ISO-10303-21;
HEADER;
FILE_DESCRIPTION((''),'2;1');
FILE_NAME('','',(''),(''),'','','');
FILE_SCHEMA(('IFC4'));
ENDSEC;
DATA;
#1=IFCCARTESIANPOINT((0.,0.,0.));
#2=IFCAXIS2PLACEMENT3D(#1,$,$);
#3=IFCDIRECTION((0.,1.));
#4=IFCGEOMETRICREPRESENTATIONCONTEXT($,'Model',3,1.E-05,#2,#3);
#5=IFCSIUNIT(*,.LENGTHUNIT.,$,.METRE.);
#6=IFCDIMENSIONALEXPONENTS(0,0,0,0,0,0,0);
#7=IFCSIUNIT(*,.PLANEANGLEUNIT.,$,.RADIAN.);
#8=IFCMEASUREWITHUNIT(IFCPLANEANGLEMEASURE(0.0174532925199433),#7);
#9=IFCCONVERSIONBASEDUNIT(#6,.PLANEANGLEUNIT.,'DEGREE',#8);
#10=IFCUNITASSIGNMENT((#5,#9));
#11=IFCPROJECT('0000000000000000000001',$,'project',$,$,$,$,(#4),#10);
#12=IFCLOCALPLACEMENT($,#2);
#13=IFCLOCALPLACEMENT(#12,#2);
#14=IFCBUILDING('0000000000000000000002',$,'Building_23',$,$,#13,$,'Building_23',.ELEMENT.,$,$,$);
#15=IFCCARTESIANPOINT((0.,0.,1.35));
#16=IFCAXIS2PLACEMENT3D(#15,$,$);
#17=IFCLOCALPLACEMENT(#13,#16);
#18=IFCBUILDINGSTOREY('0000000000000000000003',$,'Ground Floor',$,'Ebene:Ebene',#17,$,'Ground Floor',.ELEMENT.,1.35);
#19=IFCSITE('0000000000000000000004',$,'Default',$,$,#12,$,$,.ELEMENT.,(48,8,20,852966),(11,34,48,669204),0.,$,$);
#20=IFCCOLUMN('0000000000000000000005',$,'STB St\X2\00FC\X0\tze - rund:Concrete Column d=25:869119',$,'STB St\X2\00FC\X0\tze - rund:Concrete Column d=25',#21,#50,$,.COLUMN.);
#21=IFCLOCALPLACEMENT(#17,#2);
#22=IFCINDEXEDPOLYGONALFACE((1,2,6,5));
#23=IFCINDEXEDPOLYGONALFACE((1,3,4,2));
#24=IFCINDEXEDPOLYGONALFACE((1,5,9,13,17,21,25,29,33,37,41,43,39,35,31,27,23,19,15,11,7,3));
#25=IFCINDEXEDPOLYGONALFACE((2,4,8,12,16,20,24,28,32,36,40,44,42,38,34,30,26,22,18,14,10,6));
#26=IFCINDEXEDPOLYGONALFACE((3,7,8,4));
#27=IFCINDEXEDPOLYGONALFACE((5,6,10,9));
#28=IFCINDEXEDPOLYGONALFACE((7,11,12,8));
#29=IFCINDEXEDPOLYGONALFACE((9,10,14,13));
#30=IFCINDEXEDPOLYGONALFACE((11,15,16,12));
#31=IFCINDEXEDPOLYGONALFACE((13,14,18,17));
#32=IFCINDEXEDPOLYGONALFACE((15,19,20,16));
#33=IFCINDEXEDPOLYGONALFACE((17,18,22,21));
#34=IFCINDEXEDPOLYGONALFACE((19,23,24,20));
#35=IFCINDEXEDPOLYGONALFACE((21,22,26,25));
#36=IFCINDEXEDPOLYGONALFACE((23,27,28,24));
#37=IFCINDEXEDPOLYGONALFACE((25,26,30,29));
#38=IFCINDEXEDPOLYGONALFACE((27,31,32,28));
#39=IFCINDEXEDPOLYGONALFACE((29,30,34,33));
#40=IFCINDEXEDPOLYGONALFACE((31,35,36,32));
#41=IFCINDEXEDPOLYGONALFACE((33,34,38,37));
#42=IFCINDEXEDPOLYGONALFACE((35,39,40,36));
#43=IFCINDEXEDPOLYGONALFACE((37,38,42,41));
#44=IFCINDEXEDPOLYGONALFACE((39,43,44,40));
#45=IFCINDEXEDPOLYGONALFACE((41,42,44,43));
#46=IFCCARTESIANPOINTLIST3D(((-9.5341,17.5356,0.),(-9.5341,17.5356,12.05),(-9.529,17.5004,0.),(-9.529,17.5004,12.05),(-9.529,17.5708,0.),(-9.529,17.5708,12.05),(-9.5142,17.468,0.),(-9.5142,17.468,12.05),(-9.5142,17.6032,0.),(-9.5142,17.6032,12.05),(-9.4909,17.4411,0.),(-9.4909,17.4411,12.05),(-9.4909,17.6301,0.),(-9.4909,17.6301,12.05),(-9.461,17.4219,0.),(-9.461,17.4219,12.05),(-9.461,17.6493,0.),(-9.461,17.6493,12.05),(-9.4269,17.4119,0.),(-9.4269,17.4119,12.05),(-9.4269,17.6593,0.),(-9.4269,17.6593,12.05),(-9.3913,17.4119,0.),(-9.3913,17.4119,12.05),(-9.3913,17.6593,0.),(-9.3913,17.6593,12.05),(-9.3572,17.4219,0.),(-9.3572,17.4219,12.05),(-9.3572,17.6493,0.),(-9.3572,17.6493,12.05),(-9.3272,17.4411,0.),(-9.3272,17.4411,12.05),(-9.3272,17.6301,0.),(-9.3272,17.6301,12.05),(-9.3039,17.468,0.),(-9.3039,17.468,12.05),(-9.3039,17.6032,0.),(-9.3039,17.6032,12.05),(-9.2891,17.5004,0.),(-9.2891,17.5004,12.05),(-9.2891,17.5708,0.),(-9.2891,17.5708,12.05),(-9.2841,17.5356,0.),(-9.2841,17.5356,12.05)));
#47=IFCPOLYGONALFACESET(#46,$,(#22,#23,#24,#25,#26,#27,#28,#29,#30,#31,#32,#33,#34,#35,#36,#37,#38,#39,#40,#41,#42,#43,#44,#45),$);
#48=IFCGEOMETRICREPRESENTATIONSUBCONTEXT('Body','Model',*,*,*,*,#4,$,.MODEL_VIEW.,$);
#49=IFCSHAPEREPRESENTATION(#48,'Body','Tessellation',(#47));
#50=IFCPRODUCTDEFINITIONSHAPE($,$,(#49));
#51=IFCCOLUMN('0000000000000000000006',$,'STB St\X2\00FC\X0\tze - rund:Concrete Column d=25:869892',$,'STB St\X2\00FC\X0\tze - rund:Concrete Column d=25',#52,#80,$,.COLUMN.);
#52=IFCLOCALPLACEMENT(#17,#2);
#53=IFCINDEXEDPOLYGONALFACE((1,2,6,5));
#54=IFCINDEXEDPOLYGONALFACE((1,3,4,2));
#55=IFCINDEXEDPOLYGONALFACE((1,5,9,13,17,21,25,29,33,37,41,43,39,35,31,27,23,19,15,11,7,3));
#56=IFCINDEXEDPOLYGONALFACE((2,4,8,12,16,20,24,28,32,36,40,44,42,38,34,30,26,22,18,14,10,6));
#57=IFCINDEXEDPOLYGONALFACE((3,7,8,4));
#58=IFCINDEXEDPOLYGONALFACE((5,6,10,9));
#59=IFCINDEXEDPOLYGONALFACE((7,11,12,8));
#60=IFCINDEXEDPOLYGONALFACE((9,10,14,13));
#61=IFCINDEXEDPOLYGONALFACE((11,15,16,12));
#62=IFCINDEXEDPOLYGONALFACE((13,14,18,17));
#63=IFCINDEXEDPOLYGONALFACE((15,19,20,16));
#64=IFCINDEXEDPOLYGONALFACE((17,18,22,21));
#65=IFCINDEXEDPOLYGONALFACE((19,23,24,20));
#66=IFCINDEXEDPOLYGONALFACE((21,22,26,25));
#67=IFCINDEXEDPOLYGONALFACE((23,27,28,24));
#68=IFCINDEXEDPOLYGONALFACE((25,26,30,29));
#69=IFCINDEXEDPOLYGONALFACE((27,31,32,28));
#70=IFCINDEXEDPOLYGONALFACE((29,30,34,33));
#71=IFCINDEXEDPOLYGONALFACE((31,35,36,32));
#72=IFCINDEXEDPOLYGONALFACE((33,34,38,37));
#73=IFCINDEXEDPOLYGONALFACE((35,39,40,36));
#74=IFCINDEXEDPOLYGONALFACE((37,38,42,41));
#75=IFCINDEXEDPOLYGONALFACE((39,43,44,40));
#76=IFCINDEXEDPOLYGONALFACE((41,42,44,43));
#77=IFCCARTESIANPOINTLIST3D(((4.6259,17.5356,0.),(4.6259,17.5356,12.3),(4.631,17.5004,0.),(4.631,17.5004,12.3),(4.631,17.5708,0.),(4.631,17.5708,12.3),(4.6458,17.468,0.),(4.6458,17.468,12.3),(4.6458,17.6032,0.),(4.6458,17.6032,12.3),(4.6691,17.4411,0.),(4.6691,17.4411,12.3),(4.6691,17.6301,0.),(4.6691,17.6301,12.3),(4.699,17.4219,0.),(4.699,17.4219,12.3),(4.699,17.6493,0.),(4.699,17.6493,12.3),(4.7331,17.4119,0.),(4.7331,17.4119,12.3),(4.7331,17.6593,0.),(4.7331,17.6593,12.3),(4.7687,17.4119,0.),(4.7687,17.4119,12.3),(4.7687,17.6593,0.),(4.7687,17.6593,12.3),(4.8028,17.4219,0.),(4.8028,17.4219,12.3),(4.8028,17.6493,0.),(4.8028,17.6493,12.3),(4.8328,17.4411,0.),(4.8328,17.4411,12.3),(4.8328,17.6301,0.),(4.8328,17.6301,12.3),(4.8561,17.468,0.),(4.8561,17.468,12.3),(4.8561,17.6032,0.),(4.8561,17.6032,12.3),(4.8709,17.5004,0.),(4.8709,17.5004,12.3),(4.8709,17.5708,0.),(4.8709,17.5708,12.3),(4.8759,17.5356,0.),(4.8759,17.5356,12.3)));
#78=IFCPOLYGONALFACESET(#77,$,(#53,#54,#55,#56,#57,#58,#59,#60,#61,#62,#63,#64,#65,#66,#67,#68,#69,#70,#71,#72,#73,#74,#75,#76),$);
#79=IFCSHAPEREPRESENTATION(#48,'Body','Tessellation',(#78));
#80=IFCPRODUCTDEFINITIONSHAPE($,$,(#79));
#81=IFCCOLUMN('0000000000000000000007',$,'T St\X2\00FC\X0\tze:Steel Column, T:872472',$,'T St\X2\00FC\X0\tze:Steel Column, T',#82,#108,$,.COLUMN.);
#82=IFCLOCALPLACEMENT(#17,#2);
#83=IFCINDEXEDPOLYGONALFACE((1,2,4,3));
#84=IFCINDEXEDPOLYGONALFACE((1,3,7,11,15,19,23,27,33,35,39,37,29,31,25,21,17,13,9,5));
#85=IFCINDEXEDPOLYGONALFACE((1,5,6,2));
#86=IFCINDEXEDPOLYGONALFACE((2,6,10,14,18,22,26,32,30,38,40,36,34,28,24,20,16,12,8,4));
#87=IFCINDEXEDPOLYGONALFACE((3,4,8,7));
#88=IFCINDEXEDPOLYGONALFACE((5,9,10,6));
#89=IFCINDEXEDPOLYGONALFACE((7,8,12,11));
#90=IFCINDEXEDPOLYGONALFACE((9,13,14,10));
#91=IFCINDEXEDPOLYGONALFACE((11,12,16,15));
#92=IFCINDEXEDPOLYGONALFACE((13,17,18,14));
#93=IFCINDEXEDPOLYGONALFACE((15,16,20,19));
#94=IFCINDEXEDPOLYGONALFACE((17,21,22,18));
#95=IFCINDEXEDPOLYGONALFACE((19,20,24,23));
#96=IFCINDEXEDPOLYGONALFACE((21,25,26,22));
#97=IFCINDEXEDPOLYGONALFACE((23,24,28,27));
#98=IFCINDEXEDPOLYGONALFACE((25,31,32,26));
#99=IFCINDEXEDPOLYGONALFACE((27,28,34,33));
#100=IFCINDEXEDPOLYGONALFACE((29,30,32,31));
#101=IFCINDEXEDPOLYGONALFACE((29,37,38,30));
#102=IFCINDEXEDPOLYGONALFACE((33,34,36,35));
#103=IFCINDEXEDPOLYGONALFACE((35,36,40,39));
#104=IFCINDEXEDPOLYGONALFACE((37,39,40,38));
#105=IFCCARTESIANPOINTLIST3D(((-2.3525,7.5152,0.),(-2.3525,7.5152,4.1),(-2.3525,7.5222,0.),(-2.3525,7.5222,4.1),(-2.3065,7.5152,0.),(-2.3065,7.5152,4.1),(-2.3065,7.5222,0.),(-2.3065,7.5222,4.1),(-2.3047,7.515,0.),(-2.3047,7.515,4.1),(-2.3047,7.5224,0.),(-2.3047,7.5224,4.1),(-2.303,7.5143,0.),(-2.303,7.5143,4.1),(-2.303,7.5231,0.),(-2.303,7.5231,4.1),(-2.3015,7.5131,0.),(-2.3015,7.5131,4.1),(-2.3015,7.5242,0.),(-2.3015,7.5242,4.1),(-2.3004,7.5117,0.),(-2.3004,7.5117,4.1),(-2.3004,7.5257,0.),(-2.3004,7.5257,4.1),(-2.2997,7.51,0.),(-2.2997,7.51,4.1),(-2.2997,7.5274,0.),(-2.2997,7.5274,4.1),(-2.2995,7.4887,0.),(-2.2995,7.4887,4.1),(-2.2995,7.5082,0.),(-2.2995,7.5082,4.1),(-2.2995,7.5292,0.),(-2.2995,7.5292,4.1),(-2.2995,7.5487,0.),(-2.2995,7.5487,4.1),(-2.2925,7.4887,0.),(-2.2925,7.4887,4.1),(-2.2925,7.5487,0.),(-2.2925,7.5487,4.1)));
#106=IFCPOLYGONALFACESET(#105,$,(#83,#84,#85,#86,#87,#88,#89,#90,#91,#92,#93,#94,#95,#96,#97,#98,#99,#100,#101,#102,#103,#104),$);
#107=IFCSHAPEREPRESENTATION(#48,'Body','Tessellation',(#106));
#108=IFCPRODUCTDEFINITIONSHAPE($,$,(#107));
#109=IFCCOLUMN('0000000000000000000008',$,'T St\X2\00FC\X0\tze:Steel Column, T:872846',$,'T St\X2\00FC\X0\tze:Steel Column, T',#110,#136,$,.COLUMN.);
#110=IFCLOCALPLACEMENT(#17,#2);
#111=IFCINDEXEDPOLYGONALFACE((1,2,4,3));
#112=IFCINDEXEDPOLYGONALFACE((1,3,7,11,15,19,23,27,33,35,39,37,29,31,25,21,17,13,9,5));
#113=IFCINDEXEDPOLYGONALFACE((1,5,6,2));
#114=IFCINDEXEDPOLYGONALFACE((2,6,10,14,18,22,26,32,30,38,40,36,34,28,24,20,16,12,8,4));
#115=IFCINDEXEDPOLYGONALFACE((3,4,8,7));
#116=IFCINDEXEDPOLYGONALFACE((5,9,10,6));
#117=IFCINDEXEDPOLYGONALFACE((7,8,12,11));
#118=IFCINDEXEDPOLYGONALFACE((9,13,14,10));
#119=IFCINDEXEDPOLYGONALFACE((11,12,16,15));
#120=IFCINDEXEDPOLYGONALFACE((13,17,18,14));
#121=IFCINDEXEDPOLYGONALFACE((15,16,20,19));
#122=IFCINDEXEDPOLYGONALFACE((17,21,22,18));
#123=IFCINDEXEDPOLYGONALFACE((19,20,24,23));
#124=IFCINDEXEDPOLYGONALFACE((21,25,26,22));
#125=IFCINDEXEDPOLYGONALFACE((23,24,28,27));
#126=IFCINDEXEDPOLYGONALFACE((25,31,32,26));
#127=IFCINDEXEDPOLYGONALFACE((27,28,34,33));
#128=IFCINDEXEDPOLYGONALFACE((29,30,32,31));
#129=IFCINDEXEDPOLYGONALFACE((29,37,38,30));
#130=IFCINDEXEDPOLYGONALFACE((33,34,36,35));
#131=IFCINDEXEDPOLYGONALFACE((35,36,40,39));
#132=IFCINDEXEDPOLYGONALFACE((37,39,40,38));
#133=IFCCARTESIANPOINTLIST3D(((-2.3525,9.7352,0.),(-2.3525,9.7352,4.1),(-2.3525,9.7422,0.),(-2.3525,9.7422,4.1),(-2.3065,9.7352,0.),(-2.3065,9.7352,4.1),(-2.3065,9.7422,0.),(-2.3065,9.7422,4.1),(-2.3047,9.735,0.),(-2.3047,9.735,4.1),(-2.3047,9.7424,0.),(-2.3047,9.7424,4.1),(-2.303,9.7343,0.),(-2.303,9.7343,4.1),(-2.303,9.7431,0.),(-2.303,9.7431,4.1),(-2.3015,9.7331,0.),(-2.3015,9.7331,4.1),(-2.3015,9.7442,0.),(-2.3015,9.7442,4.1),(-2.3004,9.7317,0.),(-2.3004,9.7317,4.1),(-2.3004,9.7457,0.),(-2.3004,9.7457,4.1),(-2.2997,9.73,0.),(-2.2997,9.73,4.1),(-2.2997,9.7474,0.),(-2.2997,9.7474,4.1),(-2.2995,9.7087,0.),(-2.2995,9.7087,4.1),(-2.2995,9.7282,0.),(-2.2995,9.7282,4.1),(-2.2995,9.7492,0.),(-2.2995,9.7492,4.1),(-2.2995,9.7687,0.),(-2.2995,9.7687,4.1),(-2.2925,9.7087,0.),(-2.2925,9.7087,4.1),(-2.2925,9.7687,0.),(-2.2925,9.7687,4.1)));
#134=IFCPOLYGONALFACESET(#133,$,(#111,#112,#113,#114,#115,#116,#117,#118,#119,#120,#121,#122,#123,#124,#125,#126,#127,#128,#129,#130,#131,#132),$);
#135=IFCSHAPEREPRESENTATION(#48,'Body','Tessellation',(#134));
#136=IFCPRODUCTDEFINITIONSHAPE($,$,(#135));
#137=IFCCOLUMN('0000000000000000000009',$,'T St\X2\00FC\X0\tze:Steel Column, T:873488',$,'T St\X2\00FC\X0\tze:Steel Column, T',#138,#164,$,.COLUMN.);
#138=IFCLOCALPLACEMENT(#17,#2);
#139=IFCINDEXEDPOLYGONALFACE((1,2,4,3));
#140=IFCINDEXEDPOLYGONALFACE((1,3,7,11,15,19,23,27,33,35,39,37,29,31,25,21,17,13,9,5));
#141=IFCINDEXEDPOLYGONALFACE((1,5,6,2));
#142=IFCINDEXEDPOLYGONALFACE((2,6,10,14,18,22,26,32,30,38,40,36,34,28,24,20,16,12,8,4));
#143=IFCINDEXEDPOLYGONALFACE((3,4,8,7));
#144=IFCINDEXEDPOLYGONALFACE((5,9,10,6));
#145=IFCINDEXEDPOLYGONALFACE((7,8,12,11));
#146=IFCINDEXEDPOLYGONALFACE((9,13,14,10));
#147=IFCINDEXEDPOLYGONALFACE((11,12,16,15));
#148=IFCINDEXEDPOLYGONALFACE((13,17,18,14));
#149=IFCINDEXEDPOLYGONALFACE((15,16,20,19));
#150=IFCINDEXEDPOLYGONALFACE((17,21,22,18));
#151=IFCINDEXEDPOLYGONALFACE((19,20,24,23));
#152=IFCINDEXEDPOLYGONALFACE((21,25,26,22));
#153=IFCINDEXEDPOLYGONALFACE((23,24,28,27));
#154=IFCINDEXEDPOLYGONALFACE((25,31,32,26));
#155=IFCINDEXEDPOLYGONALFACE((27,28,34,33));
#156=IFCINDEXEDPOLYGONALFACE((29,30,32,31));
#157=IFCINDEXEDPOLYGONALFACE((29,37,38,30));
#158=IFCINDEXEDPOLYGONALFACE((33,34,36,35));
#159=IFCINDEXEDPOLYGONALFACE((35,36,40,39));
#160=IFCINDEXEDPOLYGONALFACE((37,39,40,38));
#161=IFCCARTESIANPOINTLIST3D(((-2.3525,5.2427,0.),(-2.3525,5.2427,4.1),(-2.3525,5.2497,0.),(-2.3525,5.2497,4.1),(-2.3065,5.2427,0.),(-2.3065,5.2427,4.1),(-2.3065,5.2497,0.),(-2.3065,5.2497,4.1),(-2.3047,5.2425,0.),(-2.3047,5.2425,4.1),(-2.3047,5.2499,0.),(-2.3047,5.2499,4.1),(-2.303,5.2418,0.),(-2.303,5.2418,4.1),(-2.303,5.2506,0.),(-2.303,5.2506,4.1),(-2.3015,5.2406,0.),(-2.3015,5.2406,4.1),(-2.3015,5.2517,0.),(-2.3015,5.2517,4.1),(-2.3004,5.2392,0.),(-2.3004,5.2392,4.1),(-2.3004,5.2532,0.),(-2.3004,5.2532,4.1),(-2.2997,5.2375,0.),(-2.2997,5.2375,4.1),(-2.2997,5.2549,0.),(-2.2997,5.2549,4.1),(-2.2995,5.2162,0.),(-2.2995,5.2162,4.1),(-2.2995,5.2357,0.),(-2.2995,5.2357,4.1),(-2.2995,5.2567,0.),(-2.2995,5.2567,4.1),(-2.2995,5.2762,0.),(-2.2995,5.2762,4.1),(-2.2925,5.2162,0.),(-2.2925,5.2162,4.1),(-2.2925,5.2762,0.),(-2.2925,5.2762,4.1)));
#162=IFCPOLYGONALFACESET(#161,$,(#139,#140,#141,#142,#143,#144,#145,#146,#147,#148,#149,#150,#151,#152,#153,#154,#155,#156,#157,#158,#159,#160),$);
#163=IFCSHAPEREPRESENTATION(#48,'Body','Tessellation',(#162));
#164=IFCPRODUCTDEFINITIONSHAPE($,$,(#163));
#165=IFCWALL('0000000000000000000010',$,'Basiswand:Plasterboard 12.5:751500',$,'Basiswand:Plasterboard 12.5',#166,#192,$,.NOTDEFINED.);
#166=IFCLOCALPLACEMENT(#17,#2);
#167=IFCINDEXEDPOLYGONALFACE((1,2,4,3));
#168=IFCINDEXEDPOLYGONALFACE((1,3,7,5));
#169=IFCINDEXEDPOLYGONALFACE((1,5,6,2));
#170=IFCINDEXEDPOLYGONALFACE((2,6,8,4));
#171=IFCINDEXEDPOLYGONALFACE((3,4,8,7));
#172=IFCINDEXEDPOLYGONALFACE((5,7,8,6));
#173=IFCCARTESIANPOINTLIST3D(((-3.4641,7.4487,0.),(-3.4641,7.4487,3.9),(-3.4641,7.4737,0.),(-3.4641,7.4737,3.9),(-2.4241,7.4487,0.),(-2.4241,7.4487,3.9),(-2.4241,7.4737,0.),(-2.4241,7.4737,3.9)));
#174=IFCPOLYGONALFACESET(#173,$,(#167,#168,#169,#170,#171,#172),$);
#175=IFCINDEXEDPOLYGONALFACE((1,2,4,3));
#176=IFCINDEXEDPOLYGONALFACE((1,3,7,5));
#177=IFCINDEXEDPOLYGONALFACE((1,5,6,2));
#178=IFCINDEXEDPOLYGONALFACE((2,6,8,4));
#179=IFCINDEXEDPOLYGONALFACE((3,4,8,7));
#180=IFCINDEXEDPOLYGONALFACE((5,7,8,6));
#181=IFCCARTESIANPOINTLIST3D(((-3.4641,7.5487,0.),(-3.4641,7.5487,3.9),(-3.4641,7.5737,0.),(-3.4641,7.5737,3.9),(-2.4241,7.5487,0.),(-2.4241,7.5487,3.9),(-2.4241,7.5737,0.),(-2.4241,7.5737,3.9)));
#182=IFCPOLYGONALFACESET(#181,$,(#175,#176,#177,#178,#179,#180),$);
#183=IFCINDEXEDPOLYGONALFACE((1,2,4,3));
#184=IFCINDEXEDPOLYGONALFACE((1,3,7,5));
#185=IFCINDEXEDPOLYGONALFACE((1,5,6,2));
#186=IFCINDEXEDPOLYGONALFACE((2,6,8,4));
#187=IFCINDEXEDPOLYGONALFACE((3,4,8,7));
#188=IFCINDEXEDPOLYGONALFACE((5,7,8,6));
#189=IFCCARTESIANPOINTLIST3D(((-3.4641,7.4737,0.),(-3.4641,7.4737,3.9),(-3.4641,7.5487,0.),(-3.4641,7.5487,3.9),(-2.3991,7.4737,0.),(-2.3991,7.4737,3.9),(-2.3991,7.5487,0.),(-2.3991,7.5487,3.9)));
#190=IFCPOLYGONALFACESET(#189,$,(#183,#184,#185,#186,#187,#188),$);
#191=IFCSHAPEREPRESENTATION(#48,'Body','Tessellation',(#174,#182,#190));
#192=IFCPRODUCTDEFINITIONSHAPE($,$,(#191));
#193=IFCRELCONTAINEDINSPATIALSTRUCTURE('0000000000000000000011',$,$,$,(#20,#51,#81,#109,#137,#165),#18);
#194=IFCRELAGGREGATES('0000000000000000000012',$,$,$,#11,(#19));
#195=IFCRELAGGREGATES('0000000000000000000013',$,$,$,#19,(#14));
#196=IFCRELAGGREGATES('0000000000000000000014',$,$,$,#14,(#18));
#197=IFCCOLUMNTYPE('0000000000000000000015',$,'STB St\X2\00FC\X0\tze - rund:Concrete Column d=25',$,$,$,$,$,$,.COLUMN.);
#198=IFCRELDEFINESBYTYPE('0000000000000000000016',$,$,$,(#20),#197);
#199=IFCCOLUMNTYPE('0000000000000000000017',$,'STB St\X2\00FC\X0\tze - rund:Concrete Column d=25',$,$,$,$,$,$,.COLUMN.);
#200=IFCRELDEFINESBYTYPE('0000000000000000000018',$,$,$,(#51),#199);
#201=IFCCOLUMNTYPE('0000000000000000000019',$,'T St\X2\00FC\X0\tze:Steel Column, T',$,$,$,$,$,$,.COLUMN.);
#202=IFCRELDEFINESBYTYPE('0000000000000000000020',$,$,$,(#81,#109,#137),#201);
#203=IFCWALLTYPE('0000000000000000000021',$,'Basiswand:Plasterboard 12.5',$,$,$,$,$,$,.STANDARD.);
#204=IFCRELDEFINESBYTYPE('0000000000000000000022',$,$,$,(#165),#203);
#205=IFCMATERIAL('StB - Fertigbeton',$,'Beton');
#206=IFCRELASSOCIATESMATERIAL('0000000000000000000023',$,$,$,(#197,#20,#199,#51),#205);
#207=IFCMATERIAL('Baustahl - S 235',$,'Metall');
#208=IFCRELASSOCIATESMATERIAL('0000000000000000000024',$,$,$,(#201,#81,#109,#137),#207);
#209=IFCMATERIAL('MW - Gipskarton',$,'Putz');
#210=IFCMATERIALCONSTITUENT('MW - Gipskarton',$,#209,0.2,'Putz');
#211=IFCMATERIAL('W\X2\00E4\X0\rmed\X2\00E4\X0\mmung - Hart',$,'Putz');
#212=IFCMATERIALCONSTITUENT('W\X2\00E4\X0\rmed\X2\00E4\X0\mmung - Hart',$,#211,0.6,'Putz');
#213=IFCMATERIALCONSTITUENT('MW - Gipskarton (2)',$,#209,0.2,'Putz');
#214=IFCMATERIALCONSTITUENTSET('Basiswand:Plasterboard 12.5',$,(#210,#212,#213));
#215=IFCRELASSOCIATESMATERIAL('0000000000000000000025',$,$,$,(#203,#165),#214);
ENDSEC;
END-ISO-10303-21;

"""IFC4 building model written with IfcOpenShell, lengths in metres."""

from ifc_helpers import new_model, entity, si_unit, converted_unit, direction, frame, origin, place, context, subcontext, project, spatial, line, arc, indexed_curve, outline, extrude, source, transform, mapped, material, constituent, constituent_set, type_object, type_shapes, element, save


model = new_model("IFC4")

# Units and contexts
model_context = context("Model", 3, precision=1e-05, world=origin(), true_north=direction((0.0, 1.0)))
body_context = subcontext(model_context, "Body", "Model", "MODEL_VIEW")
ifc_project = project(units=[si_unit("LENGTHUNIT", "METRE"), converted_unit("PLANEANGLEUNIT", "DEGREE", entity("IfcPlaneAngleMeasure", 0.0174532925199433), si_unit("PLANEANGLEUNIT", "RADIAN"), dimensions=[0, 0, 0, 0, 0, 0, 0])], contexts=[model_context])

# Site, building, storey
site_placement = place(None, origin())
site = spatial("IfcSite", under=ifc_project, at=site_placement, Name="Default", CompositionType="ELEMENT", RefLatitude=(48, 8, 20, 852966), RefLongitude=(11, 34, 48, 669204), RefElevation=0.0)
building_placement = place(site_placement, origin())
building = spatial("IfcBuilding", under=site, at=building_placement, Name="Building_23", LongName="Building_23", CompositionType="ELEMENT")
storey_placement = place(building_placement, frame((0.0, 0.0, 1.35)))
storey = spatial("IfcBuildingStorey", under=building, at=storey_placement, Name="Ground Floor", ObjectType="Ebene:Ebene", LongName="Ground Floor", CompositionType="ELEMENT", Elevation=1.35)

# Columns
ifc_material_1 = material(Name="StB - Fertigbeton", Category="Beton")
column_type_1 = type_object("IfcColumnType", Name="STB Stütze - rund:Concrete Column d=25", PredefinedType="COLUMN", material=ifc_material_1)
shared_shape_1 = source(origin(), body_context, "Body", "SweptSolid", [
    extrude(outline(indexed_curve([(-0.125, 0.0), (0.0, -0.125), (0.125, 0.0), (0.0, 0.125)], segments=[arc(1, 2, 3), arc(3, 4, 1)], self_intersect=False)), frame((-9.4091, 17.5356, 1.35)), (0.0, 0.0, 1.0), 12.05),
])
type_shapes(column_type_1, [shared_shape_1])
column_1_placement = place(storey_placement, frame((0.0, 0.0, -1.35)))
element("IfcColumn", 1, at=column_1_placement, inside=storey, type_object=column_type_1, material=ifc_material_1, Name="STB Stütze - rund:Concrete Column d=25:869119", ObjectType="STB Stütze - rund:Concrete Column d=25", PredefinedType="COLUMN", context=body_context, shape_type="MappedRepresentation", body=[
    mapped(shared_shape_1, transform((0.0, 0.0, 0.0), scale=1.0)),
])
column_type_2 = type_object("IfcColumnType", Name="STB Stütze - rund:Concrete Column d=25", PredefinedType="COLUMN", material=ifc_material_1)
shared_shape_2 = source(origin(), body_context, "Body", "SweptSolid", [
    extrude(outline(indexed_curve([(-0.125, 0.0), (0.0, -0.125), (0.125, 0.0), (0.0, 0.125)], segments=[arc(1, 2, 3), arc(3, 4, 1)], self_intersect=False)), frame((4.7509, 17.5356, 1.35), z_axis=(0.0, 0.0, 1.0), x_axis=(-1.0, 0.0, 0.0)), (0.0, 0.0, 1.0), 12.3),
])
type_shapes(column_type_2, [shared_shape_2])
column_2_placement = place(storey_placement, frame((0.0, 0.0, -1.35)))
element("IfcColumn", 2, at=column_2_placement, inside=storey, type_object=column_type_2, material=ifc_material_1, Name="STB Stütze - rund:Concrete Column d=25:869892", ObjectType="STB Stütze - rund:Concrete Column d=25", PredefinedType="COLUMN", context=body_context, shape_type="MappedRepresentation", body=[
    mapped(shared_shape_2, transform((0.0, 0.0, 0.0), scale=1.0)),
])
ifc_material_2 = material(Name="Baustahl - S 235", Category="Metall")
column_type_3 = type_object("IfcColumnType", Name="T Stütze:Steel Column, T", PredefinedType="COLUMN", material=ifc_material_2)
shared_shape_3 = source(origin(), body_context, "Body", "SweptSolid", [
    extrude(outline(indexed_curve([(-0.03, -0.0106), (-0.03, -0.0176), (0.03, -0.0176), (0.03, -0.0106), (0.0105, -0.0106), (0.0056, -0.0085), (0.0035, -0.0036), (0.0035, 0.0424), (-0.0035, 0.0424), (-0.0035, -0.0036), (-0.0056, -0.0085), (-0.0105, -0.0106)], segments=[line(1, 2, 3, 4, 5), arc(5, 6, 7), line(7, 8, 9, 10), arc(10, 11, 12), line(12, 1)], self_intersect=False)), frame((0.0, -0.001, 1.35), z_axis=(0.0, 0.0, -1.0), x_axis=(1.0, 0.0, 0.0)), (0.0, 0.0, -1.0), 4.1),
])
type_shapes(column_type_3, [shared_shape_3])
for number, where, z_axis, x_axis, name in (
    (3, (-2.3091, 7.5187, -1.35), (0.0, 0.0, 1.0), (0.0, -1.0, 0.0), "T Stütze:Steel Column, T:872472"),
    (4, (-2.3091, 9.7387, -1.35), (0.0, 0.0, 1.0), (0.0, -1.0, 0.0), "T Stütze:Steel Column, T:872846"),
    (5, (-2.3091, 5.2462, -1.35), (0.0, 0.0, 1.0), (0.0, -1.0, 0.0), "T Stütze:Steel Column, T:873488"),
):
    element("IfcColumn", number, at=place(storey_placement, frame(where, z_axis=z_axis, x_axis=x_axis)), inside=storey, type_object=column_type_3, material=ifc_material_2, Name=name, ObjectType="T Stütze:Steel Column, T", PredefinedType="COLUMN", context=body_context, shape_type="MappedRepresentation", body=[
        mapped(shared_shape_3, transform((0.0, 0.0, 0.0), scale=1.0)),
    ])

# Shared definitions
ifc_material_3 = material(Name="Wärmedämmung - Hart", Category="Putz")

# Shared definitions
ifc_material_4 = material(Name="MW - Gipskarton", Category="Putz")
ifc_constituent_1 = constituent(ifc_material_4, Name="MW - Gipskarton", Category="Putz", fraction=0.2)
ifc_constituent_2 = constituent(ifc_material_3, Name="Wärmedämmung - Hart", Category="Putz", fraction=0.6)
ifc_constituent_3 = constituent(ifc_material_4, Name="MW - Gipskarton (2)", Category="Putz", fraction=0.2)
ifc_constituent_set_1 = constituent_set(constituents=[ifc_constituent_1, ifc_constituent_2, ifc_constituent_3], Name="Basiswand:Plasterboard 12.5")
wall_type_1 = type_object("IfcWallType", Name="Basiswand:Plasterboard 12.5", PredefinedType="STANDARD", material=ifc_constituent_set_1)

# Wall
wall_1_placement = place(storey_placement, frame((-3.4491, 7.5112, 0.0)))
element("IfcWall", 6, at=wall_1_placement, inside=storey, type_object=wall_type_1, material=ifc_constituent_set_1, Name="Basiswand:Plasterboard 12.5:751500", ObjectType="Basiswand:Plasterboard 12.5", PredefinedType="NOTDEFINED", context=body_context, shape_type="SweptSolid", body=[
    extrude(outline(indexed_curve([(-0.0125, -0.52), (0.0125, -0.52), (0.0125, 0.52), (-0.0125, 0.52), (-0.0125, -0.52)], self_intersect=False)), frame((0.505, -0.05, 0.0), z_axis=(0.0, 0.0, 1.0), x_axis=(0.0, 1.0, 0.0)), (0.0, 0.0, 1.0), 3.9),
    extrude(outline(indexed_curve([(-0.0125, -0.52), (0.0125, -0.52), (0.0125, 0.52), (-0.0125, 0.52), (-0.0125, -0.52)], self_intersect=False)), frame((0.505, 0.05, 0.0), z_axis=(0.0, 0.0, 1.0), x_axis=(0.0, -1.0, 0.0)), (0.0, 0.0, 1.0), 3.9),
    extrude(outline(indexed_curve([(-0.5325, -0.0375), (0.5325, -0.0375), (0.5325, 0.0375), (-0.5325, 0.0375), (-0.5325, -0.0375)], self_intersect=False)), frame((0.5175, 0.0, 0.0)), (0.0, 0.0, 1.0), 3.9),
])

save(model, "model.ifc")
